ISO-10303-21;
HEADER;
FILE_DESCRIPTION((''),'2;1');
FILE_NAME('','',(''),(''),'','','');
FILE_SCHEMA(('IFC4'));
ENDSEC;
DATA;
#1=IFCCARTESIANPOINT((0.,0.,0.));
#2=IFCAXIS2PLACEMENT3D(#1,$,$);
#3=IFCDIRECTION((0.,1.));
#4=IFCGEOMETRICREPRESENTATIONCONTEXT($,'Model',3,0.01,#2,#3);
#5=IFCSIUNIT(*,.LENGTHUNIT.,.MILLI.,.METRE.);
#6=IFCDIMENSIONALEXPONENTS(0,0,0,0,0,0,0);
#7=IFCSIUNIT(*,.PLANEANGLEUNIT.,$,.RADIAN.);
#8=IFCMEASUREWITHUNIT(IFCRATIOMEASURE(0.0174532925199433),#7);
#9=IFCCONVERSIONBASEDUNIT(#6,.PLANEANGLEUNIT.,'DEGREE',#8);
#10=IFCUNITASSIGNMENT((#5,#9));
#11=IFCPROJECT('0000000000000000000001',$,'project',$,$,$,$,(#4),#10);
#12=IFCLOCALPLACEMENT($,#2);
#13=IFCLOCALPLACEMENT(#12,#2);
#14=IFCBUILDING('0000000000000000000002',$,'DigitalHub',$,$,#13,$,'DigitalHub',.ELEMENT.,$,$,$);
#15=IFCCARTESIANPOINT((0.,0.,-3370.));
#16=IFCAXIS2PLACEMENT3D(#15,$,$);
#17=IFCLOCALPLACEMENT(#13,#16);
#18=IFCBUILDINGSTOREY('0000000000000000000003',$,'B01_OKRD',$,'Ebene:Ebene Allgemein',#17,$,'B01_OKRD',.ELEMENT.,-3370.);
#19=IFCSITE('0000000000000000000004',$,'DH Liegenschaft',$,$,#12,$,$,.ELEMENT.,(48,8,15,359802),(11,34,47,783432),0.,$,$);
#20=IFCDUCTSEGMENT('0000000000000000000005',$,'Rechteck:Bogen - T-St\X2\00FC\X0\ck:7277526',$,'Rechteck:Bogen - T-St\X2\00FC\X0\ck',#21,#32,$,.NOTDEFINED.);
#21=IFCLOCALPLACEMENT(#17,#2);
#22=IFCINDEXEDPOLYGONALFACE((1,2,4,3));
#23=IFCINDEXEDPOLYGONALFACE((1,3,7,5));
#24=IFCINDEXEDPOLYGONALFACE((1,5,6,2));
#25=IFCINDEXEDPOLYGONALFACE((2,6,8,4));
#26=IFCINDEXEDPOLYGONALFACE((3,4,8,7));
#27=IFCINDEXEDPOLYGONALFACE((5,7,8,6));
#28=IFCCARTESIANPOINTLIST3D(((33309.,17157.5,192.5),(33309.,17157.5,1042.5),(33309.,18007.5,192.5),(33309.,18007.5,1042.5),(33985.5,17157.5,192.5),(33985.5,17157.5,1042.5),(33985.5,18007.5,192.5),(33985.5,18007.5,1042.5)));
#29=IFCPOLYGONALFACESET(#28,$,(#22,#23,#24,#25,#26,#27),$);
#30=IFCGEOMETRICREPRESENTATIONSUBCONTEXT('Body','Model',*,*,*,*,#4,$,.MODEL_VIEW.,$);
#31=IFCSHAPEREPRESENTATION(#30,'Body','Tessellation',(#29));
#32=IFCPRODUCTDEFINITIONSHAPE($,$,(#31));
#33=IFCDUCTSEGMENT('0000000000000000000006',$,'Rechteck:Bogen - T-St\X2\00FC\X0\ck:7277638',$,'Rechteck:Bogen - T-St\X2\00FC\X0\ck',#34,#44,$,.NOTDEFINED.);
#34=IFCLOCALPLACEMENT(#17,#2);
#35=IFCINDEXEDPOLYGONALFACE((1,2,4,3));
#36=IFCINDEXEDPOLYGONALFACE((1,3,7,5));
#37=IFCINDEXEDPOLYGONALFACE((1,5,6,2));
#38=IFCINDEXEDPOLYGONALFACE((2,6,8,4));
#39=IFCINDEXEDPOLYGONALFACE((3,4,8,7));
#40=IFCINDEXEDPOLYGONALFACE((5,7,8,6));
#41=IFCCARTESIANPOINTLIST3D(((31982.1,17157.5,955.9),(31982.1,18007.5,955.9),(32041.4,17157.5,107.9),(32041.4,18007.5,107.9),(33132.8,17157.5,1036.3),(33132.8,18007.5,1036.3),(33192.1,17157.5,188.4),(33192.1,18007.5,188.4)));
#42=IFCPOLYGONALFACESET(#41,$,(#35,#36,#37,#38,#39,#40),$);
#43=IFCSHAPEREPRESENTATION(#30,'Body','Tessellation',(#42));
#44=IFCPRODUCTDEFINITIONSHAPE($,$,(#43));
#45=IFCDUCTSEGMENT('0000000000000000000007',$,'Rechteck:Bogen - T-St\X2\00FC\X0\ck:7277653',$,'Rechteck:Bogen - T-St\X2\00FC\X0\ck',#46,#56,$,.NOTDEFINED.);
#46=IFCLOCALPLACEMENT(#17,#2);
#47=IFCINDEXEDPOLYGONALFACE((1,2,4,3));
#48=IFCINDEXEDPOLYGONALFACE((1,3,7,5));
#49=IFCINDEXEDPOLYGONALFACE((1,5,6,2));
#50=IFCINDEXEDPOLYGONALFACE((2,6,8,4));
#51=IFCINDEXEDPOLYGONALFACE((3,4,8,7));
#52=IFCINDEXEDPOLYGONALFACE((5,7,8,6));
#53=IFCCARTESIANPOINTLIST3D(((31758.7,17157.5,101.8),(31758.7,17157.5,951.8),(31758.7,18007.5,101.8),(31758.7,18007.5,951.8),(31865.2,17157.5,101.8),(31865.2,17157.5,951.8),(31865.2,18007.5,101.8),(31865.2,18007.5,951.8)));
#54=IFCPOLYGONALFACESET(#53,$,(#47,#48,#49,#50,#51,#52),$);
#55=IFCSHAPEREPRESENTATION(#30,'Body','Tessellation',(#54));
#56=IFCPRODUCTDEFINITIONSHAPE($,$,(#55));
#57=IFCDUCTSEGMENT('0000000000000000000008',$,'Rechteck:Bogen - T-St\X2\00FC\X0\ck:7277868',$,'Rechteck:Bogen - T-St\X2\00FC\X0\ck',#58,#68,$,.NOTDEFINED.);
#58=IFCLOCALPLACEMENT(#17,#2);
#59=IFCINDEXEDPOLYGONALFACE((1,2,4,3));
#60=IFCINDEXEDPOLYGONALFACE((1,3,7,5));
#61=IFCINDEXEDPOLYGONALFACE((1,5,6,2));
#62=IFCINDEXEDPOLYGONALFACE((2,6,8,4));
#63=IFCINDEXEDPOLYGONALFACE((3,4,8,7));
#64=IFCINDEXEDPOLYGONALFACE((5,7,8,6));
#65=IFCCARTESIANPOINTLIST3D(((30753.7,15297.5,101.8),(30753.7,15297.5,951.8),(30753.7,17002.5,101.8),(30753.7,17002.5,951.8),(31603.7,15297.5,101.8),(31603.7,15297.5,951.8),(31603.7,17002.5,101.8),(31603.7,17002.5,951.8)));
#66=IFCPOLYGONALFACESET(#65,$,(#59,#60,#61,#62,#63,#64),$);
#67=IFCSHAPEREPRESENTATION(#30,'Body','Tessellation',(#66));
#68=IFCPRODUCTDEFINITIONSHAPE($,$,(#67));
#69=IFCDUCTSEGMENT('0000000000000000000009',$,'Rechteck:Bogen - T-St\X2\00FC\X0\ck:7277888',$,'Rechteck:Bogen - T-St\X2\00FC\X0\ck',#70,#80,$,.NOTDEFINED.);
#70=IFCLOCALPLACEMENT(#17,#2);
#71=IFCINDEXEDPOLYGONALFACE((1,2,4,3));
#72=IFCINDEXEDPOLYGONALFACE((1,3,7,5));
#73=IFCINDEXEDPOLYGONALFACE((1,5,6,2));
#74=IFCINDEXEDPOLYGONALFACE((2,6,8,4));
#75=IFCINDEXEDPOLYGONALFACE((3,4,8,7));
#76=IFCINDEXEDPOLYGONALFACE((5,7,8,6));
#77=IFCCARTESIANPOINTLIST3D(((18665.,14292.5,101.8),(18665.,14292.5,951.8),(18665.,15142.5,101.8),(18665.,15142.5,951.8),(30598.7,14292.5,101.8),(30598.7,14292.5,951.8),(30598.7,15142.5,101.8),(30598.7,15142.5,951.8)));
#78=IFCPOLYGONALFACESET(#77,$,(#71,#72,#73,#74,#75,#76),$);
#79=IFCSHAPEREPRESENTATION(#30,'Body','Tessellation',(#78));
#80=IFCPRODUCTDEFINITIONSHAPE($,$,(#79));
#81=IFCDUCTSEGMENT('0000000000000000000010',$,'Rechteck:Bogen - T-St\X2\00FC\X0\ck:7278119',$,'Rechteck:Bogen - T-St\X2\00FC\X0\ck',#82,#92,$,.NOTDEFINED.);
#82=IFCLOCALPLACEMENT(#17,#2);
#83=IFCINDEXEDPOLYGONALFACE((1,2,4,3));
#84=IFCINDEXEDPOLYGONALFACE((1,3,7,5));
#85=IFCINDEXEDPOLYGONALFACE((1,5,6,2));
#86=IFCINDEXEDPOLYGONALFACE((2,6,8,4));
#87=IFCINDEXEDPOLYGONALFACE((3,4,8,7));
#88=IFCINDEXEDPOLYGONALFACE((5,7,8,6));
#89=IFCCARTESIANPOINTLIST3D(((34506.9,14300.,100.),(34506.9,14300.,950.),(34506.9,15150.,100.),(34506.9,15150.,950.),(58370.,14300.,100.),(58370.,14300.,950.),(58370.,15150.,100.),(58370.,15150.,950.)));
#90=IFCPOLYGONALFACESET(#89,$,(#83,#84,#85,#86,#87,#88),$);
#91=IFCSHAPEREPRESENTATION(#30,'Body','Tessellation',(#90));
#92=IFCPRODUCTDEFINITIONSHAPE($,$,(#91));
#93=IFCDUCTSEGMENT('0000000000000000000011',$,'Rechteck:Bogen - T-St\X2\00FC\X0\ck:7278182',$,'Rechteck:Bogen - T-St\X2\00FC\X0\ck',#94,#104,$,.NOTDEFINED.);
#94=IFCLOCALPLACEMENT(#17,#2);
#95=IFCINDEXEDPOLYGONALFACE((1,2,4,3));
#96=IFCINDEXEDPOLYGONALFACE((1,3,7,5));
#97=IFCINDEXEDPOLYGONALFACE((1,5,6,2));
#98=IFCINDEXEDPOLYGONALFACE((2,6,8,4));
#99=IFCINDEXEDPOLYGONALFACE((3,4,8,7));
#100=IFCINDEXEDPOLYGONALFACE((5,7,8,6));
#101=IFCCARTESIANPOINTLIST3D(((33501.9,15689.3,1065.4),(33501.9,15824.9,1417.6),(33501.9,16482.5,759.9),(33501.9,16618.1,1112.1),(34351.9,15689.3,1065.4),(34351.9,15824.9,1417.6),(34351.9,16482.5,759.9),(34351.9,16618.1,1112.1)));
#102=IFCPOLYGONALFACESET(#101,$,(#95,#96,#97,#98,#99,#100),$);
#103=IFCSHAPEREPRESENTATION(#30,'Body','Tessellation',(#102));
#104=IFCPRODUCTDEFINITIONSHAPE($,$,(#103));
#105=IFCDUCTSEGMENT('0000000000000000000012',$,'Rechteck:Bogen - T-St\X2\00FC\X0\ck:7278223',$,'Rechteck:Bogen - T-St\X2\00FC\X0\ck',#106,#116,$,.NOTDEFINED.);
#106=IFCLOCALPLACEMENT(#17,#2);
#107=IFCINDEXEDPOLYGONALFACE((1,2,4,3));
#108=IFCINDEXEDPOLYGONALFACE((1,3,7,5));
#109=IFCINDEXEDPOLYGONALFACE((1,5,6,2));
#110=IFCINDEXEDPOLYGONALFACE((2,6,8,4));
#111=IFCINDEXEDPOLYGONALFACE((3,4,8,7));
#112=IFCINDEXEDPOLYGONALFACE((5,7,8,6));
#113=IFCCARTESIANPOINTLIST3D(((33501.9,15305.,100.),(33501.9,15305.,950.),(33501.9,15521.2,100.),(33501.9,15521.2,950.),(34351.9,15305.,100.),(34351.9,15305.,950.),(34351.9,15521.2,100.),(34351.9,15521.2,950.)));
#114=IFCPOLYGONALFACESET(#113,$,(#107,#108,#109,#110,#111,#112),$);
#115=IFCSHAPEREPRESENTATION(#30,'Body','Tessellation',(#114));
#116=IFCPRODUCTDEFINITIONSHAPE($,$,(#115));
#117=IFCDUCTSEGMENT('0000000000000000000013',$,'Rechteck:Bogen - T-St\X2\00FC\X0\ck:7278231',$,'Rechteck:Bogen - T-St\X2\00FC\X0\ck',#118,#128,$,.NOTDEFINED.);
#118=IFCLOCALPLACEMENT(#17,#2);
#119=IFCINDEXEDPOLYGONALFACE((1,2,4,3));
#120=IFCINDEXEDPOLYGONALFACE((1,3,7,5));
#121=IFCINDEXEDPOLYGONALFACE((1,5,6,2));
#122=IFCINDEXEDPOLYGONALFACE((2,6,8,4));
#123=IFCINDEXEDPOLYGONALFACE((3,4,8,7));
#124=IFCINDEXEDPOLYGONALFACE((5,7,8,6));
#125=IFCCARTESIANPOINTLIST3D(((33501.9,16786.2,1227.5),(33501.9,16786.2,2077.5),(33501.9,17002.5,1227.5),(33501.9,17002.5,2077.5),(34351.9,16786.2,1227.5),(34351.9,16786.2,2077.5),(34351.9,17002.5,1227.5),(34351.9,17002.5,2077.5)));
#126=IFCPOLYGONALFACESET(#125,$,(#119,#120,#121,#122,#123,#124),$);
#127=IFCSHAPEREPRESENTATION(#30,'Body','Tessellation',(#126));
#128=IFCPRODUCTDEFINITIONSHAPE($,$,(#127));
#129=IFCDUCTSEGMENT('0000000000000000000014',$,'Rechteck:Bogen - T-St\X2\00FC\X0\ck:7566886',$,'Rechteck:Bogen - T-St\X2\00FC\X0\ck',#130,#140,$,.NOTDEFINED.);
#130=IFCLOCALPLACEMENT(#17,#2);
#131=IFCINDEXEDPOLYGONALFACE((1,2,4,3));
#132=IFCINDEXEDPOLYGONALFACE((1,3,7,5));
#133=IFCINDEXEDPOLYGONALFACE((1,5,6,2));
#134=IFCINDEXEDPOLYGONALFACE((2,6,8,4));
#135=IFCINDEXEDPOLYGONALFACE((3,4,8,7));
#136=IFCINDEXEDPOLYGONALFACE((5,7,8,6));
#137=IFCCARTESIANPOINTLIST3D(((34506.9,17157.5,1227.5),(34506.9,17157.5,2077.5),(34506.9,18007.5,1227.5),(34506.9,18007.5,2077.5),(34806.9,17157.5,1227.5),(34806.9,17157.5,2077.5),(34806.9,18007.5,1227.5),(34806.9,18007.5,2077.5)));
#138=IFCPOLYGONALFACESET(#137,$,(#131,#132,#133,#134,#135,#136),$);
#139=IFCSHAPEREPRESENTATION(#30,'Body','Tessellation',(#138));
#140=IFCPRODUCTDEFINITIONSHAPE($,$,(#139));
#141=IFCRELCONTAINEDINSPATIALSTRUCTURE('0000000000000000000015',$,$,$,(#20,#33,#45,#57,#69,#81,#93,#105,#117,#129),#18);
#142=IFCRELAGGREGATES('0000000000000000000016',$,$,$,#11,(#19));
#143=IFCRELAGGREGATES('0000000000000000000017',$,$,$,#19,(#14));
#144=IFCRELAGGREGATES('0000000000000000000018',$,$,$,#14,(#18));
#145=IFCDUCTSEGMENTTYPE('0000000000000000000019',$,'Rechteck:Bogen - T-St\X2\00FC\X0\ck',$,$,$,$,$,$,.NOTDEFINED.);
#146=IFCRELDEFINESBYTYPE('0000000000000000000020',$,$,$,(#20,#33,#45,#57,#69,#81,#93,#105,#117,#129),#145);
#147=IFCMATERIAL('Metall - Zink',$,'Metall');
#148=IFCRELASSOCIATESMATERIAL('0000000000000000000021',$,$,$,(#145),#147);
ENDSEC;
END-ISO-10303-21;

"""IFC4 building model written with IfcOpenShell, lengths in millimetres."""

from ifc_helpers import new_model, entity, si_unit, converted_unit, direction, frame, origin, place, context, subcontext, project, spatial, indexed_curve, outline, extrude, material, type_object, element, save


model = new_model("IFC4")

# Units and contexts
model_context = context("Model", 3, precision=0.01, world=origin(), true_north=direction((0.0, 1.0)))
body_context = subcontext(model_context, "Body", "Model", "MODEL_VIEW")
ifc_project = project(units=[si_unit("LENGTHUNIT", "METRE", prefix="MILLI"), converted_unit("PLANEANGLEUNIT", "DEGREE", entity("IfcRatioMeasure", 0.0174532925199433), si_unit("PLANEANGLEUNIT", "RADIAN"), dimensions=[0, 0, 0, 0, 0, 0, 0])], contexts=[model_context])

# Site, building, storey
site_placement = place(None, origin())
site = spatial("IfcSite", under=ifc_project, at=site_placement, Name="DH Liegenschaft", CompositionType="ELEMENT", RefLatitude=(48, 8, 15, 359802), RefLongitude=(11, 34, 47, 783432), RefElevation=0.0)
building_placement = place(site_placement, origin())
building = spatial("IfcBuilding", under=site, at=building_placement, Name="DigitalHub", LongName="DigitalHub", CompositionType="ELEMENT")
storey_placement = place(building_placement, frame((0.0, 0.0, -3370.0)))
storey = spatial("IfcBuildingStorey", under=building, at=storey_placement, Name="B01_OKRD", ObjectType="Ebene:Ebene Allgemein", LongName="B01_OKRD", CompositionType="ELEMENT", Elevation=-3370.0)

# Duct segments
ifc_material_1 = material(Name="Metall - Zink", Category="Metall")
duct_segment_type_1 = type_object("IfcDuctSegmentType", Name="Rechteck:Bogen - T-Stück", PredefinedType="NOTDEFINED", material=ifc_material_1)
duct_segment_1_placement = place(storey_placement, frame((33309.0, 17157.5, 192.5)))
element("IfcDuctSegment", 1, at=duct_segment_1_placement, inside=storey, type_object=duct_segment_type_1, Name="Rechteck:Bogen - T-Stück:7277526", ObjectType="Rechteck:Bogen - T-Stück", PredefinedType="NOTDEFINED", context=body_context, shape_type="SweptSolid", body=[
    extrude(outline(indexed_curve([(-338.3, -425.0), (338.3, -425.0), (338.3, 425.0), (-338.3, 425.0), (-338.3, -425.0)], self_intersect=False)), frame((338.3, 425.0, 0.0), z_axis=(0.0, 0.0, 1.0), x_axis=(-1.0, 0.0, 0.0)), (0.0, 0.0, 1.0), 850.0),
])
duct_segment_2_placement = place(storey_placement, frame((31982.1, 17157.5, 107.9)))
element("IfcDuctSegment", 2, at=duct_segment_2_placement, inside=storey, type_object=duct_segment_type_1, Name="Rechteck:Bogen - T-Stück:7277638", ObjectType="Rechteck:Bogen - T-Stück", PredefinedType="NOTDEFINED", context=body_context, shape_type="SweptSolid", body=[
    extrude(outline(indexed_curve([(-425.0, -425.0), (425.0, -425.0), (425.0, 425.0), (-425.0, 425.0), (-425.0, -425.0)], self_intersect=False)), frame((29.6, 425.0, 424.0), z_axis=(0.997564, 0.0, 0.069756), x_axis=(0.0, 1.0, 0.0)), (0.0, 0.0, 1.0), 1153.6),
])
duct_segment_3_placement = place(storey_placement, frame((31758.7, 17157.5, 101.8)))
element("IfcDuctSegment", 3, at=duct_segment_3_placement, inside=storey, type_object=duct_segment_type_1, Name="Rechteck:Bogen - T-Stück:7277653", ObjectType="Rechteck:Bogen - T-Stück", PredefinedType="NOTDEFINED", context=body_context, shape_type="SweptSolid", body=[
    extrude(outline(indexed_curve([(-53.3, -425.0), (53.3, -425.0), (53.3, 425.0), (-53.3, 425.0), (-53.3, -425.0)], self_intersect=False)), frame((53.3, 425.0, 0.0), z_axis=(0.0, 0.0, 1.0), x_axis=(-1.0, 0.0, 0.0)), (0.0, 0.0, 1.0), 850.0),
])
duct_segment_4_placement = place(storey_placement, frame((30753.7, 15297.5, 101.8)))
element("IfcDuctSegment", 4, at=duct_segment_4_placement, inside=storey, type_object=duct_segment_type_1, Name="Rechteck:Bogen - T-Stück:7277868", ObjectType="Rechteck:Bogen - T-Stück", PredefinedType="NOTDEFINED", context=body_context, shape_type="SweptSolid", body=[
    extrude(outline(indexed_curve([(-852.5, -425.0), (852.5, -425.0), (852.5, 425.0), (-852.5, 425.0), (-852.5, -425.0)], self_intersect=False)), frame((425.0, 852.5, 0.0), z_axis=(0.0, 0.0, 1.0), x_axis=(0.0, -1.0, 0.0)), (0.0, 0.0, 1.0), 850.0),
])
duct_segment_5_placement = place(storey_placement, frame((18665.0, 14292.5, 101.8)))
element("IfcDuctSegment", 5, at=duct_segment_5_placement, inside=storey, type_object=duct_segment_type_1, Name="Rechteck:Bogen - T-Stück:7277888", ObjectType="Rechteck:Bogen - T-Stück", PredefinedType="NOTDEFINED", context=body_context, shape_type="SweptSolid", body=[
    extrude(outline(indexed_curve([(-5966.9, -425.0), (5966.9, -425.0), (5966.9, 425.0), (-5966.9, 425.0), (-5966.9, -425.0)], self_intersect=False)), frame((5966.9, 425.0, 0.0), z_axis=(0.0, 0.0, 1.0), x_axis=(-1.0, 0.0, 0.0)), (0.0, 0.0, 1.0), 850.0),
])
duct_segment_6_placement = place(storey_placement, frame((34506.9, 14300.0, 100.0)))
element("IfcDuctSegment", 6, at=duct_segment_6_placement, inside=storey, type_object=duct_segment_type_1, Name="Rechteck:Bogen - T-Stück:7278119", ObjectType="Rechteck:Bogen - T-Stück", PredefinedType="NOTDEFINED", context=body_context, shape_type="SweptSolid", body=[
    extrude(outline(indexed_curve([(-11931.5, -425.0), (11931.5, -425.0), (11931.5, 425.0), (-11931.5, 425.0), (-11931.5, -425.0)], self_intersect=False)), frame((11931.5, 425.0, 0.0)), (0.0, 0.0, 1.0), 850.0),
])
duct_segment_7_placement = place(storey_placement, frame((33501.9, 15689.3, 759.9)))
element("IfcDuctSegment", 7, at=duct_segment_7_placement, inside=storey, type_object=duct_segment_type_1, Name="Rechteck:Bogen - T-Stück:7278182", ObjectType="Rechteck:Bogen - T-Stück", PredefinedType="NOTDEFINED", context=body_context, shape_type="SweptSolid", body=[
    extrude(outline(indexed_curve([(-188.7, -425.0), (188.7, -425.0), (188.7, 425.0), (-188.7, 425.0), (-188.7, -425.0)], self_intersect=False)), frame((0.0, 464.4, 328.8), z_axis=(1.0, 0.0, 0.0), x_axis=(0.0, -0.359372, -0.933194)), (0.0, 0.0, 1.0), 850.0),
])
duct_segment_8_placement = place(storey_placement, frame((33501.9, 15305.0, 100.0)))
element("IfcDuctSegment", 8, at=duct_segment_8_placement, inside=storey, type_object=duct_segment_type_1, Name="Rechteck:Bogen - T-Stück:7278223", ObjectType="Rechteck:Bogen - T-Stück", PredefinedType="NOTDEFINED", context=body_context, shape_type="SweptSolid", body=[
    extrude(outline(indexed_curve([(-108.1, -425.0), (108.1, -425.0), (108.1, 425.0), (-108.1, 425.0), (-108.1, -425.0)], self_intersect=False)), frame((425.0, 108.1, 0.0), z_axis=(0.0, 0.0, 1.0), x_axis=(0.0, 1.0, 0.0)), (0.0, 0.0, 1.0), 850.0),
])
duct_segment_9_placement = place(storey_placement, frame((33501.9, 16786.2, 1227.5)))
element("IfcDuctSegment", 9, at=duct_segment_9_placement, inside=storey, type_object=duct_segment_type_1, Name="Rechteck:Bogen - T-Stück:7278231", ObjectType="Rechteck:Bogen - T-Stück", PredefinedType="NOTDEFINED", context=body_context, shape_type="SweptSolid", body=[
    extrude(outline(indexed_curve([(-108.1, -425.0), (108.1, -425.0), (108.1, 425.0), (-108.1, 425.0), (-108.1, -425.0)], self_intersect=False)), frame((425.0, 108.1, 0.0), z_axis=(0.0, 0.0, 1.0), x_axis=(0.0, -1.0, 0.0)), (0.0, 0.0, 1.0), 850.0),
])
duct_segment_10_placement = place(storey_placement, frame((34506.9, 17157.5, 1227.5)))
element("IfcDuctSegment", 10, at=duct_segment_10_placement, inside=storey, type_object=duct_segment_type_1, Name="Rechteck:Bogen - T-Stück:7566886", ObjectType="Rechteck:Bogen - T-Stück", PredefinedType="NOTDEFINED", context=body_context, shape_type="SweptSolid", body=[
    extrude(outline(indexed_curve([(-150.0, -425.0), (150.0, -425.0), (150.0, 425.0), (-150.0, 425.0), (-150.0, -425.0)], self_intersect=False)), frame((150.0, 425.0, 0.0), z_axis=(0.0, 0.0, 1.0), x_axis=(-1.0, 0.0, 0.0)), (0.0, 0.0, 1.0), 850.0),
])

save(model, "model.ifc")
